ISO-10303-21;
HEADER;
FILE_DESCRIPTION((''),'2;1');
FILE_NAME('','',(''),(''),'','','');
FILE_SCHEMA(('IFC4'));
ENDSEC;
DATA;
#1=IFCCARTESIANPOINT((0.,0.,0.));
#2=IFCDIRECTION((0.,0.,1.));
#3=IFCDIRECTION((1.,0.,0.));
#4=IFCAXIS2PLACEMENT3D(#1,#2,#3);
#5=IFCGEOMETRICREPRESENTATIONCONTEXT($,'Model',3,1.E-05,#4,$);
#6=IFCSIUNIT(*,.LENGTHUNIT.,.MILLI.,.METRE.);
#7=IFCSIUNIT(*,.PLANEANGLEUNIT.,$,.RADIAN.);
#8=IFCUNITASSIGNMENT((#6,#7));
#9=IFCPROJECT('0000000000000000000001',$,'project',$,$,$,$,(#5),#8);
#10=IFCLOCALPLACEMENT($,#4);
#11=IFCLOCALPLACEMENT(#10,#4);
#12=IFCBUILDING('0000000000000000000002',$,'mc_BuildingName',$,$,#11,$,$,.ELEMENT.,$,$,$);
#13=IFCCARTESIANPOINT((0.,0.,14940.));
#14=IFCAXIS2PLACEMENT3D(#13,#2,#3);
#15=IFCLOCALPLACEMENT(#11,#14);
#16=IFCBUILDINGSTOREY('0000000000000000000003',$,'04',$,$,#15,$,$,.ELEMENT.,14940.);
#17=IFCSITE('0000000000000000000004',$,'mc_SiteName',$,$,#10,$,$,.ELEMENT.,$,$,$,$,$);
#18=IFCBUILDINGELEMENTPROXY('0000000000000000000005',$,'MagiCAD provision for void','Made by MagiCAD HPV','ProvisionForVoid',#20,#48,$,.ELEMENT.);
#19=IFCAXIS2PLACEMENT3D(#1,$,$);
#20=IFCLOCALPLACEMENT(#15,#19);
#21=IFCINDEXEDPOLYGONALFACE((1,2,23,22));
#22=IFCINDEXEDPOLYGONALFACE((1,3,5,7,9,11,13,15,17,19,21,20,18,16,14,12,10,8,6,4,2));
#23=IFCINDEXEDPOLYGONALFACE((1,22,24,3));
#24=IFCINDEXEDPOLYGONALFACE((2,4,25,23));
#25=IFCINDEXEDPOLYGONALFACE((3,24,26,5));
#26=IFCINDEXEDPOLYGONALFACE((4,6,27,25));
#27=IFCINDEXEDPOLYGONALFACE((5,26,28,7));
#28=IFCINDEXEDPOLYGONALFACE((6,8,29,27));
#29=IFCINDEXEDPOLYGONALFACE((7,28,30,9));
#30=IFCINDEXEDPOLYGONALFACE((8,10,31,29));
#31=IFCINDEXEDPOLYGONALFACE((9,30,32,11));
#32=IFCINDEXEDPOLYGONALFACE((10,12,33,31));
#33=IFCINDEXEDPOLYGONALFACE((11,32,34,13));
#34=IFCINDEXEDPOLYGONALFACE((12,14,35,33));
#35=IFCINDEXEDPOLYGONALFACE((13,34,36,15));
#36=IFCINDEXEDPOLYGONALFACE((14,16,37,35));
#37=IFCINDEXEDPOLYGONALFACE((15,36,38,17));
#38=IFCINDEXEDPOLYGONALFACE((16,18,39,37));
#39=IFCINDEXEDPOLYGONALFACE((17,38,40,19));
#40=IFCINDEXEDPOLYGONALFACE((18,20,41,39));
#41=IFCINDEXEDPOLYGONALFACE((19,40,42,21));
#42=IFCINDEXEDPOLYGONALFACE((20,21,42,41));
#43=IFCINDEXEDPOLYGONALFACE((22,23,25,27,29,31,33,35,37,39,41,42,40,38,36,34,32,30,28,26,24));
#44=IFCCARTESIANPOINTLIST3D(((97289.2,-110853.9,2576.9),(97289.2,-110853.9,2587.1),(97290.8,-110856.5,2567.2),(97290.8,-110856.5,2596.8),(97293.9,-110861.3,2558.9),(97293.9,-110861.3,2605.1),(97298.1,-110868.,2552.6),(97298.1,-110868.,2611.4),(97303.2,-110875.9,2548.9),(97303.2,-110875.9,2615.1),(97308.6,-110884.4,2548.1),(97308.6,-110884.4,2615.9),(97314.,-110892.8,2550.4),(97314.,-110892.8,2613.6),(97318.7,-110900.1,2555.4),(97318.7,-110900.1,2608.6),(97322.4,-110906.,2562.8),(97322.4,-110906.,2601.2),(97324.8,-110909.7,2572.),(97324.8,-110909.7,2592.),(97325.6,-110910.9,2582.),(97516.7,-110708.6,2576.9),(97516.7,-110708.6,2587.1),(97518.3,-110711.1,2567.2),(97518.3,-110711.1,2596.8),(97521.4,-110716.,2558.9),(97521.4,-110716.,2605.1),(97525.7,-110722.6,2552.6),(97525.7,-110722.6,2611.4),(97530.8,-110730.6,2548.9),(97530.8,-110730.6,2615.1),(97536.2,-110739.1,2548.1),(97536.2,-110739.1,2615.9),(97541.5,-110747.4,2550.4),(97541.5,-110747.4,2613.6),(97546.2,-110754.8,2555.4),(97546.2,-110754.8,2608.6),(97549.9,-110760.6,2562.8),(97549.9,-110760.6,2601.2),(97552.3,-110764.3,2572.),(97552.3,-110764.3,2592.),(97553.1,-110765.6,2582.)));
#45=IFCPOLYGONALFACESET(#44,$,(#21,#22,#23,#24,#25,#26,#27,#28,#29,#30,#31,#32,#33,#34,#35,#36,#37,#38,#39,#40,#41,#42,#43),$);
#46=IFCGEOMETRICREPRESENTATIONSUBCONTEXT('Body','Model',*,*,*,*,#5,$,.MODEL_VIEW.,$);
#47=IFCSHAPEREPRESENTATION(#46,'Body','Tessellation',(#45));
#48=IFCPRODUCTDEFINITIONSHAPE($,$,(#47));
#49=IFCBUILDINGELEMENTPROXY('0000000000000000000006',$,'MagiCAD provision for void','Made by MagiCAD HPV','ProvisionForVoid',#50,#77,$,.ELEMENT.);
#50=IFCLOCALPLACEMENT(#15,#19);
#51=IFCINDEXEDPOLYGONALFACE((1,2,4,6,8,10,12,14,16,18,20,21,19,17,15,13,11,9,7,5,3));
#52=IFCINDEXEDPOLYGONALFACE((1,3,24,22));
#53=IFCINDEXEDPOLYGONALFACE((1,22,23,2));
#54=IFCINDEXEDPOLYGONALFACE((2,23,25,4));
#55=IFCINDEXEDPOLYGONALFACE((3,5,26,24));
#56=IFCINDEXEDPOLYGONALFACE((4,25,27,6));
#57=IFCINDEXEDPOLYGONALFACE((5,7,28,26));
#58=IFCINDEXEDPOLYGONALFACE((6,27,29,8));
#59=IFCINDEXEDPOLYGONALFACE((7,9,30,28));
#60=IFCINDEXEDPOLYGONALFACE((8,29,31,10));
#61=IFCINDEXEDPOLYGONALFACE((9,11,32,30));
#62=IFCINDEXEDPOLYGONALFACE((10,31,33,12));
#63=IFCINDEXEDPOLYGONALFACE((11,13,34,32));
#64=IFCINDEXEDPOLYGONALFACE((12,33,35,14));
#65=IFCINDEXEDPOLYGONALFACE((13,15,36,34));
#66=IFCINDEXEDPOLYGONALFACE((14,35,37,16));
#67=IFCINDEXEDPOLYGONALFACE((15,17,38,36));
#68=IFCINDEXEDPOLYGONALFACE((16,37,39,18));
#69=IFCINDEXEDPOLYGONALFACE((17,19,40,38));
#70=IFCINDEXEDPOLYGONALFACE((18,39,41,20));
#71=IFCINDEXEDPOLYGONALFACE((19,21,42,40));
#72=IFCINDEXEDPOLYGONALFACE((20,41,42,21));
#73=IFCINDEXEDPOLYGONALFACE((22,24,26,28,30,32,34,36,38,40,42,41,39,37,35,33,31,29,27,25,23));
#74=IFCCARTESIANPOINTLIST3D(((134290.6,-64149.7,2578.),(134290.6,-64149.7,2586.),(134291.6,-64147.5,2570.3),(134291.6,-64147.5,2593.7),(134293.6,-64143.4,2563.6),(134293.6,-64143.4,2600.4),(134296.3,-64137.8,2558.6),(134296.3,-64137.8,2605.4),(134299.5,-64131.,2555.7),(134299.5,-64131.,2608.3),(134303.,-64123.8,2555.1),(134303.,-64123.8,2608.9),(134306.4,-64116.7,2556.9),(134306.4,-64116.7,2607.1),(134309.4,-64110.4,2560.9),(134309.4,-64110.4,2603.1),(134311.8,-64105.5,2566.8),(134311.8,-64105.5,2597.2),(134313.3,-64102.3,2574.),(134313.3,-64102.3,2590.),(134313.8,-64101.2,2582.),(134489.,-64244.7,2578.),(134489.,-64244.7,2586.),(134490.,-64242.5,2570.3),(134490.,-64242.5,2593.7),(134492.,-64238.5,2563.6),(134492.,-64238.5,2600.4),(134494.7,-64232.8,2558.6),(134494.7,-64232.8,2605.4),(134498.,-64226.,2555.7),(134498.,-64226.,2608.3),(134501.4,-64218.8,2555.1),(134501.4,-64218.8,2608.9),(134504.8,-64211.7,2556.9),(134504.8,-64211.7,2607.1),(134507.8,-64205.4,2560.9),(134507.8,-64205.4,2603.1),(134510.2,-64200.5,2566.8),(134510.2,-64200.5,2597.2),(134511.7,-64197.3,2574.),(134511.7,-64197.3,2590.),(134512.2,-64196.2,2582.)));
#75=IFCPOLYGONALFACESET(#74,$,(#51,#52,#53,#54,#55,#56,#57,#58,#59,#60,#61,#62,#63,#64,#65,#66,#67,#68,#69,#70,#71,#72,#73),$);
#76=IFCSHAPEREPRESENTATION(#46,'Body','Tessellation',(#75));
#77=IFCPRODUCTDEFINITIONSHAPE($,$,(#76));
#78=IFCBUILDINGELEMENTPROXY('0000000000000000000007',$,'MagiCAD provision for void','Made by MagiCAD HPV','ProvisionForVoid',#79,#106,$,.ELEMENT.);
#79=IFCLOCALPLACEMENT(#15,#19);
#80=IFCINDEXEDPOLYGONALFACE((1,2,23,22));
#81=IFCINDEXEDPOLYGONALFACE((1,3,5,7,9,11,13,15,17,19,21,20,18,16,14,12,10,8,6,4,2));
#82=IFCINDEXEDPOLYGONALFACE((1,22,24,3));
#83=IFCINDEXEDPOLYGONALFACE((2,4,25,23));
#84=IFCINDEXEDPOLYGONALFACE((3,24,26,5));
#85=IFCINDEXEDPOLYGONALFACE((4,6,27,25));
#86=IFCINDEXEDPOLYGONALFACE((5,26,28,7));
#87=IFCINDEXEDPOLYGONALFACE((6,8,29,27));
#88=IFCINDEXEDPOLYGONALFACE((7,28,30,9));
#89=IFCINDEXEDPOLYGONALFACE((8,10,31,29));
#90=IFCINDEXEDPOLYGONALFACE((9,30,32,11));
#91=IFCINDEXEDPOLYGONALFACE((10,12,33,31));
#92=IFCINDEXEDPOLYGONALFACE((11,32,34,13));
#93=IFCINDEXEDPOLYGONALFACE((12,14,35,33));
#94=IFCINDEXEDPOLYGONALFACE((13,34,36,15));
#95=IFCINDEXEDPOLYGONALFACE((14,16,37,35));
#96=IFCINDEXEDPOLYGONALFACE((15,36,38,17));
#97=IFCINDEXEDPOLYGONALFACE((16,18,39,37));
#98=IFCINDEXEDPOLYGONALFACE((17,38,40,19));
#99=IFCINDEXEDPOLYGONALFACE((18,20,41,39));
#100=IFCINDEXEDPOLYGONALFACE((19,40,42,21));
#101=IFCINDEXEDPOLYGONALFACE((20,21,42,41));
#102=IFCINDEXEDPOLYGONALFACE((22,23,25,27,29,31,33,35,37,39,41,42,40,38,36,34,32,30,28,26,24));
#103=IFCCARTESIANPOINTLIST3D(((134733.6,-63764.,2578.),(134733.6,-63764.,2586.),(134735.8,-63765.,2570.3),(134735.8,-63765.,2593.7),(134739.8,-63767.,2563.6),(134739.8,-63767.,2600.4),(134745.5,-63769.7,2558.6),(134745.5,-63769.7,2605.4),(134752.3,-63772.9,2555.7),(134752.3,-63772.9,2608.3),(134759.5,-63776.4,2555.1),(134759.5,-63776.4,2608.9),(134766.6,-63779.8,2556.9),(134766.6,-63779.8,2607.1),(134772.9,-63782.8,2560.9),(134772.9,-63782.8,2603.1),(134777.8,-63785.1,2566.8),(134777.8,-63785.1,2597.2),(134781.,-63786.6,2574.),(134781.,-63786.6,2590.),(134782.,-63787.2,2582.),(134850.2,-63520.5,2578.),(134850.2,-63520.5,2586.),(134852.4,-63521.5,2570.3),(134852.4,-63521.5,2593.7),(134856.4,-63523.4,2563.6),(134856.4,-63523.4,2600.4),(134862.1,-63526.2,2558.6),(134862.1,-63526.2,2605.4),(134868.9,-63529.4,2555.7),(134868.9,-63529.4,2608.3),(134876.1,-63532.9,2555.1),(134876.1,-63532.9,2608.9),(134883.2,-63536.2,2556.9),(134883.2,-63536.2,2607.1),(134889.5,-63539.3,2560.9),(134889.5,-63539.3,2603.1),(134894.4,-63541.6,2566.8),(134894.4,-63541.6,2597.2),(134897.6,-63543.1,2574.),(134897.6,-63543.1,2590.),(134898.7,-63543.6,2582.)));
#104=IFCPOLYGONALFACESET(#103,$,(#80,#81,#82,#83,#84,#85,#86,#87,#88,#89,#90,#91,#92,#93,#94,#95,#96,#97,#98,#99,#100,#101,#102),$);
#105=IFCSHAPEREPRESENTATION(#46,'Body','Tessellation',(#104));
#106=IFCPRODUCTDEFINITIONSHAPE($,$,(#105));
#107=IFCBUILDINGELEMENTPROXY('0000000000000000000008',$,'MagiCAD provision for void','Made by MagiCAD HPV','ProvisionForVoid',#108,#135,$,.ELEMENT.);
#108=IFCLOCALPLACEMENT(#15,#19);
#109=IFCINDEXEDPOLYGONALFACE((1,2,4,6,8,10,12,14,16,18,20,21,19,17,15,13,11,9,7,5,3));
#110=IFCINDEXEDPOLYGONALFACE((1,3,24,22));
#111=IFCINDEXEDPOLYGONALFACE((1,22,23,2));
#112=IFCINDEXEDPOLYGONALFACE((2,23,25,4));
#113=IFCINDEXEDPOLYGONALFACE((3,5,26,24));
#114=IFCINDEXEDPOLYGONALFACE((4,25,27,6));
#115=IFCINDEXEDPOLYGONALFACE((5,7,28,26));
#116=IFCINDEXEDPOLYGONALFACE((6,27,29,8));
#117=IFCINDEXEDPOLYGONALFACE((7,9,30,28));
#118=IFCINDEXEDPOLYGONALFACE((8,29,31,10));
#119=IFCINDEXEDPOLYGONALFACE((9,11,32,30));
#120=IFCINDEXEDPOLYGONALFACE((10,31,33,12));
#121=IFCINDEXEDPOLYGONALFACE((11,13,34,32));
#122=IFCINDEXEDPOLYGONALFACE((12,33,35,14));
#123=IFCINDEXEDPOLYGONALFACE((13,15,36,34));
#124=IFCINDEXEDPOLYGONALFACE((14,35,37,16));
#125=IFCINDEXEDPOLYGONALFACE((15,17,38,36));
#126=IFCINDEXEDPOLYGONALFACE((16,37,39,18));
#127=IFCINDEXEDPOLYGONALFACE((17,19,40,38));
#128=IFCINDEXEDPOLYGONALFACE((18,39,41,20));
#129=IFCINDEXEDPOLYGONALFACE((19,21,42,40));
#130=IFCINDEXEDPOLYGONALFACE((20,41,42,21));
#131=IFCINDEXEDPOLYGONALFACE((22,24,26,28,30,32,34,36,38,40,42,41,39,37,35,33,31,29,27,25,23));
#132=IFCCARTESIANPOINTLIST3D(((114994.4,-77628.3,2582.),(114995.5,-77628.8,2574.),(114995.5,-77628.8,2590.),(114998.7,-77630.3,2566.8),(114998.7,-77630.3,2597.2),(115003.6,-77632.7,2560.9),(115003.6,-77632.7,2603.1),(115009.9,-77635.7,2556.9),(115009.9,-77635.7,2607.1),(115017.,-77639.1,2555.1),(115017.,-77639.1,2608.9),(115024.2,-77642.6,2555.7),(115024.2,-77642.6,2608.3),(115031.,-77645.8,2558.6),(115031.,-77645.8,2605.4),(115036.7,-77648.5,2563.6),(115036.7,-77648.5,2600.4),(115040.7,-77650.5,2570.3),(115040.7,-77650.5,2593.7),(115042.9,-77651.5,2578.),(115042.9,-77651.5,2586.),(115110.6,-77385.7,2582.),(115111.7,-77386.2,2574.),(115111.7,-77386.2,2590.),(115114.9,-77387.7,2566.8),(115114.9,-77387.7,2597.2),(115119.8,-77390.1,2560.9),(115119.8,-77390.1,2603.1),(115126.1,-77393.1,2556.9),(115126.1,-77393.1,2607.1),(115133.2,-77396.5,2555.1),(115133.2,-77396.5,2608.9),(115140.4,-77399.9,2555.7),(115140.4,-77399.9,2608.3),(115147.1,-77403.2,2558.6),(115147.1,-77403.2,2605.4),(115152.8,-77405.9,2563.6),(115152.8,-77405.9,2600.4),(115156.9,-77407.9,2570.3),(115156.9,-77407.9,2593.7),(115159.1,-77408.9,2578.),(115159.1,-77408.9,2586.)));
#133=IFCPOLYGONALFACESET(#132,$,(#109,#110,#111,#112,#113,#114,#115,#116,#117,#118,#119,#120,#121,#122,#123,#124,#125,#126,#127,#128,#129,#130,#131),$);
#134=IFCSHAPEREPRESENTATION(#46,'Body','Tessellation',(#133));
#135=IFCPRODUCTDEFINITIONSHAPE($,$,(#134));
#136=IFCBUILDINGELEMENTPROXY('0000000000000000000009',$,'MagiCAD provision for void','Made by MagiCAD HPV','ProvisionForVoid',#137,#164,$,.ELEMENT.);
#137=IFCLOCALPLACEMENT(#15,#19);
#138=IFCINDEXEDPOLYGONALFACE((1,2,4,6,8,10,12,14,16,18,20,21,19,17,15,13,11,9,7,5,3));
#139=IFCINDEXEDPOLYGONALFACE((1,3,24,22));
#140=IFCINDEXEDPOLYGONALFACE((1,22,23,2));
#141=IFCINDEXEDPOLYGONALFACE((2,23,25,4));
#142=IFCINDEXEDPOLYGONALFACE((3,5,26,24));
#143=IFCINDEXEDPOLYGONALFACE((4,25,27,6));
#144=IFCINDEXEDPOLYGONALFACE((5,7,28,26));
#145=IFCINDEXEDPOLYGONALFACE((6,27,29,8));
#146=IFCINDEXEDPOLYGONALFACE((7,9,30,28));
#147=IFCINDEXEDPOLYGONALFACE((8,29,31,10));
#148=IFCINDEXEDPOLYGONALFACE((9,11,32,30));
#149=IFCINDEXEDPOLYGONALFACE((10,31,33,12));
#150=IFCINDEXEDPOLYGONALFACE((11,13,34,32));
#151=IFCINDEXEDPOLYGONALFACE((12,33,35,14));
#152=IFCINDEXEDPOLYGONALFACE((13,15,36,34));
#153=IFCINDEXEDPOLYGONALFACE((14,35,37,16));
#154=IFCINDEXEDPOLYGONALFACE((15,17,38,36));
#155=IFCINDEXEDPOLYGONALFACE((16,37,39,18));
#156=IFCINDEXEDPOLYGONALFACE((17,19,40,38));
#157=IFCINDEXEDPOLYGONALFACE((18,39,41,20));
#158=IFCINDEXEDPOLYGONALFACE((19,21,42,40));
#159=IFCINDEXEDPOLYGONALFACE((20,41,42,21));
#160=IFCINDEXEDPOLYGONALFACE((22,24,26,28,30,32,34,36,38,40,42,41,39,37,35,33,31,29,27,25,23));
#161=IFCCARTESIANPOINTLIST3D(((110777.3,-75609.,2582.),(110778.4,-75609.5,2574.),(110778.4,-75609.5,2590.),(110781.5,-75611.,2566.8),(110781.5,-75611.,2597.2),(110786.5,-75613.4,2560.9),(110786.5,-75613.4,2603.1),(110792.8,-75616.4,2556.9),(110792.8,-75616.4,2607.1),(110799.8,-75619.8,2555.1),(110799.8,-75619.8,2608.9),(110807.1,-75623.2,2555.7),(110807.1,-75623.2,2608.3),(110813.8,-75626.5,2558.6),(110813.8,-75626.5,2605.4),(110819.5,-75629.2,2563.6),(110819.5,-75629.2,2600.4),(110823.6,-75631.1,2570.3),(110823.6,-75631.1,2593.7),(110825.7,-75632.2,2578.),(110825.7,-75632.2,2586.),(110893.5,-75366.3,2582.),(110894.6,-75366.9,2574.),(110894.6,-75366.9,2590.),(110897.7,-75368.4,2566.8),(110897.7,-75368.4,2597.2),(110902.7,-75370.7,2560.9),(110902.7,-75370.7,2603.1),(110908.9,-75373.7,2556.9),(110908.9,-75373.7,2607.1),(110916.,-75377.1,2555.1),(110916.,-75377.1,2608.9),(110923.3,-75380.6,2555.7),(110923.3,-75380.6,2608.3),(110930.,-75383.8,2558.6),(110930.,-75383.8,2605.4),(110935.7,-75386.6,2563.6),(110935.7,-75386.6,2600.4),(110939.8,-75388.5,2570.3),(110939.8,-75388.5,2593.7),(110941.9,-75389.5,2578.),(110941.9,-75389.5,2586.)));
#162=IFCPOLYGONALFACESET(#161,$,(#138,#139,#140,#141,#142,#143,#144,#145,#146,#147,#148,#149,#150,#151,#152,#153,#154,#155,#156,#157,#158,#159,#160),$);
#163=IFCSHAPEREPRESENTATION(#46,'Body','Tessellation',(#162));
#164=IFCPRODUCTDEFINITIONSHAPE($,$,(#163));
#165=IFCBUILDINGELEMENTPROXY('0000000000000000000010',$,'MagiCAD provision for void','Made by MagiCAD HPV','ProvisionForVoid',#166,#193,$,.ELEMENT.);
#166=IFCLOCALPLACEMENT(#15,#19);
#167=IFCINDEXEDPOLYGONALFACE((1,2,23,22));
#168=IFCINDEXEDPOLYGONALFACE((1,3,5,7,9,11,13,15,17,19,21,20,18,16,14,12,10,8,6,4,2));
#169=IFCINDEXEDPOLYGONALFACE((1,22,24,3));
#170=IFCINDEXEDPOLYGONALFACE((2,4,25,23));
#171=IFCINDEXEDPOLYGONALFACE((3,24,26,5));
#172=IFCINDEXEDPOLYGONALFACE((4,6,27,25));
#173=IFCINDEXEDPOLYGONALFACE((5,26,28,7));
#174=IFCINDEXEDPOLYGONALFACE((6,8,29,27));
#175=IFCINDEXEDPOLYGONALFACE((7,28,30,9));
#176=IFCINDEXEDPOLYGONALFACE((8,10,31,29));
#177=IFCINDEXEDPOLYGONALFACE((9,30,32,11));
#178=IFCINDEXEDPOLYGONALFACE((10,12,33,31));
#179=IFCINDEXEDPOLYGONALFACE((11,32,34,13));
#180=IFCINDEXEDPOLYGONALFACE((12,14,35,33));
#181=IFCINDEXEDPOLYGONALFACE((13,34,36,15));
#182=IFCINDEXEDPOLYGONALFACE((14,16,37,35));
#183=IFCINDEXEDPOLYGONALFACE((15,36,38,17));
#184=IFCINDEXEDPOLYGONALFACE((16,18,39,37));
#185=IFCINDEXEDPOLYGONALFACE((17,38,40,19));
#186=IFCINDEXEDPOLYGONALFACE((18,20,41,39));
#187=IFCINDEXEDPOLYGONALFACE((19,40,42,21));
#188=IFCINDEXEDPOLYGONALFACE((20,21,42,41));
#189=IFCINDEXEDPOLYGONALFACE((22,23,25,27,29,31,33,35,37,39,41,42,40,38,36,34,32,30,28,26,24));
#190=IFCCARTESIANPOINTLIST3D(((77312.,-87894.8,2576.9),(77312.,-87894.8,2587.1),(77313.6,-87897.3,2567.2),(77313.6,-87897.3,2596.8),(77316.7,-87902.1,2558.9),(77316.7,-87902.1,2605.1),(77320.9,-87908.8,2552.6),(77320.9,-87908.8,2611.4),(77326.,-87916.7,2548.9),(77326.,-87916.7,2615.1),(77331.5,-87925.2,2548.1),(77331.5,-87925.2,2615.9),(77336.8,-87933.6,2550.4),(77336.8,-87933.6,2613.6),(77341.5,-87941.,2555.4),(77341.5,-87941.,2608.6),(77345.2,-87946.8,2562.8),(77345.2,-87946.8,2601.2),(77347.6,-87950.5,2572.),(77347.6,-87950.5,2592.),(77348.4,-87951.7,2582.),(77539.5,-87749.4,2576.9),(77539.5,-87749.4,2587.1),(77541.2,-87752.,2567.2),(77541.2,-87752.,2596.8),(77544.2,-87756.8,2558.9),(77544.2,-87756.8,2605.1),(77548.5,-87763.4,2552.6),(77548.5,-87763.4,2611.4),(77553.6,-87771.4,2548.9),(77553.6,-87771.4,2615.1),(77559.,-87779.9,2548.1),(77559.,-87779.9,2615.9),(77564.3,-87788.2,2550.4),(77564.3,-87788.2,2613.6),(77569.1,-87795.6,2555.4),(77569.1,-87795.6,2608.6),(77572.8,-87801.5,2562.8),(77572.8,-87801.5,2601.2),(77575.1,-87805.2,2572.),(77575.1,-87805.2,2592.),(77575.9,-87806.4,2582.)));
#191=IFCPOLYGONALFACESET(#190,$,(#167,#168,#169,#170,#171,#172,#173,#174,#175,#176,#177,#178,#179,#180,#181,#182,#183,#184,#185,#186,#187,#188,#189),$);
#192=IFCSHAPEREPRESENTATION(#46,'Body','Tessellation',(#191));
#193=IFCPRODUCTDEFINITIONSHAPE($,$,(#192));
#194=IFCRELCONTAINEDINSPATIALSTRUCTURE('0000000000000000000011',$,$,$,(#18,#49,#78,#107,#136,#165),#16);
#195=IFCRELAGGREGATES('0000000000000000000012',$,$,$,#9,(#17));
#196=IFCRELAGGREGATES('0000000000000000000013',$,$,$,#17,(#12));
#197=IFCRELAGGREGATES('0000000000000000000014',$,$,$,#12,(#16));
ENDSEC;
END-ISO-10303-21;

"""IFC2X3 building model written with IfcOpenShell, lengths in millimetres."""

from ifc_helpers import new_model, si_unit, frame, origin_with_axes, origin_2d_with_axis, place, context, subcontext, project, spatial, circle, extrude, source, transform, mapped, element, save


model = new_model("IFC2X3")

# Units and contexts
model_context = context("Model", 3, precision=1e-05, world=origin_with_axes())
body_context = subcontext(model_context, "Body", "Model", "MODEL_VIEW")
ifc_project = project(units=[si_unit("LENGTHUNIT", "METRE", prefix="MILLI"), si_unit("PLANEANGLEUNIT", "RADIAN")], contexts=[model_context])

# Site, building, storey
site_placement = place(None, origin_with_axes())
site = spatial("IfcSite", under=ifc_project, at=site_placement, Name="mc_SiteName", CompositionType="ELEMENT")
building_placement = place(site_placement, origin_with_axes())
building = spatial("IfcBuilding", under=site, at=building_placement, Name="mc_BuildingName", CompositionType="ELEMENT")
storey_placement = place(building_placement, frame((0.0, 0.0, 14940.0), z_axis=(0.0, 0.0, 1.0), x_axis=(1.0, 0.0, 0.0)))
storey = spatial("IfcBuildingStorey", under=building, at=storey_placement, Name="04", CompositionType="ELEMENT", Elevation=14940.0)

# Building element proxies
shared_shape_1 = source(origin_with_axes(), body_context, "Body", "SweptSolid", [
    extrude(circle(Radius=34.0, at=origin_2d_with_axis()), frame((0.0, 0.0, 0.0), z_axis=(1.0, 0.0, 0.0), x_axis=(0.0, 1.0, 0.0)), (0.0, 0.0, 1.0), 270.0),
])
proxy_1_placement = place(storey_placement, frame((97534.8, -110737.0, 2582.0), z_axis=(0.0, 0.0, 1.0), x_axis=(-0.842809, -0.538213, 0.0)))
element("IfcBuildingElementProxy", 1, at=proxy_1_placement, inside=storey, Name="MagiCAD provision for void", Description="Made by MagiCAD HPV", ObjectType="ProvisionForVoid", CompositionType="ELEMENT", context=body_context, shape_type="MappedRepresentation", body=[
    mapped(shared_shape_1, transform((0.0, 0.0, 0.0), scale=1.0)),
])
shared_shape_2 = source(origin_with_axes(), body_context, "Body", "SweptSolid", [
    extrude(circle(Radius=27.0, at=origin_2d_with_axis()), frame((0.0, 0.0, 0.0), z_axis=(1.0, 0.0, 0.0), x_axis=(0.0, 1.0, 0.0)), (0.0, 0.0, 1.0), 220.0),
])
proxy_2_placement = place(storey_placement, frame((134302.1, -64125.6, 2582.0), z_axis=(0.0, 0.0, 1.0), x_axis=(0.901941, -0.431859, 0.0)))
element("IfcBuildingElementProxy", 2, at=proxy_2_placement, inside=storey, Name="MagiCAD provision for void", Description="Made by MagiCAD HPV", ObjectType="ProvisionForVoid", CompositionType="ELEMENT", context=body_context, shape_type="MappedRepresentation", body=[
    mapped(shared_shape_2, transform((0.0, 0.0, 0.0), scale=1.0)),
])
shared_shape_3 = source(origin_with_axes(), body_context, "Body", "SweptSolid", [
    extrude(circle(Radius=27.0, at=origin_2d_with_axis()), frame((0.0, 0.0, 0.0), z_axis=(1.0, 0.0, 0.0), x_axis=(0.0, 1.0, 0.0)), (0.0, 0.0, 1.0), 270.0),
])
proxy_3_placement = place(storey_placement, frame((134874.3, -63532.0, 2582.0), z_axis=(0.0, 0.0, 1.0), x_axis=(-0.431882, -0.90193, 0.0)))
element("IfcBuildingElementProxy", 3, at=proxy_3_placement, inside=storey, Name="MagiCAD provision for void", Description="Made by MagiCAD HPV", ObjectType="ProvisionForVoid", CompositionType="ELEMENT", context=body_context, shape_type="MappedRepresentation", body=[
    mapped(shared_shape_3, transform((0.0, 0.0, 0.0), scale=1.0)),
])
shared_shape_4 = source(origin_with_axes(), body_context, "Body", "SweptSolid", [
    extrude(circle(Radius=27.0, at=origin_2d_with_axis()), frame((0.0, 0.0, 0.0), z_axis=(1.0, 0.0, 0.0), x_axis=(0.0, 1.0, 0.0)), (0.0, 0.0, 1.0), 269.0),
])
proxy_4_placement = place(storey_placement, frame((115018.8, -77640.0, 2582.0), z_axis=(0.0, 0.0, 1.0), x_axis=(0.431859, 0.901941, 0.0)))
element("IfcBuildingElementProxy", 4, at=proxy_4_placement, inside=storey, Name="MagiCAD provision for void", Description="Made by MagiCAD HPV", ObjectType="ProvisionForVoid", CompositionType="ELEMENT", context=body_context, shape_type="MappedRepresentation", body=[
    mapped(shared_shape_4, transform((0.0, 0.0, 0.0), scale=1.0)),
])
shared_shape_5 = source(origin_with_axes(), body_context, "Body", "SweptSolid", [
    extrude(circle(Radius=27.0, at=origin_2d_with_axis()), frame((0.0, 0.0, 0.0), z_axis=(1.0, 0.0, 0.0), x_axis=(0.0, 1.0, 0.0)), (0.0, 0.0, 1.0), 269.0),
])
proxy_5_placement = place(storey_placement, frame((110801.7, -75620.6, 2582.0), z_axis=(0.0, 0.0, 1.0), x_axis=(0.431859, 0.901941, 0.0)))
element("IfcBuildingElementProxy", 5, at=proxy_5_placement, inside=storey, Name="MagiCAD provision for void", Description="Made by MagiCAD HPV", ObjectType="ProvisionForVoid", CompositionType="ELEMENT", context=body_context, shape_type="MappedRepresentation", body=[
    mapped(shared_shape_5, transform((0.0, 0.0, 0.0), scale=1.0)),
])
shared_shape_6 = source(origin_with_axes(), body_context, "Body", "SweptSolid", [
    extrude(circle(Radius=34.0, at=origin_2d_with_axis()), frame((0.0, 0.0, 0.0), z_axis=(1.0, 0.0, 0.0), x_axis=(0.0, 1.0, 0.0)), (0.0, 0.0, 1.0), 270.0),
])
proxy_6_placement = place(storey_placement, frame((77557.6, -87777.8, 2582.0), z_axis=(0.0, 0.0, 1.0), x_axis=(-0.842809, -0.538213, 0.0)))
element("IfcBuildingElementProxy", 6, at=proxy_6_placement, inside=storey, Name="MagiCAD provision for void", Description="Made by MagiCAD HPV", ObjectType="ProvisionForVoid", CompositionType="ELEMENT", context=body_context, shape_type="MappedRepresentation", body=[
    mapped(shared_shape_6, transform((0.0, 0.0, 0.0), scale=1.0)),
])

save(model, "model.ifc")
